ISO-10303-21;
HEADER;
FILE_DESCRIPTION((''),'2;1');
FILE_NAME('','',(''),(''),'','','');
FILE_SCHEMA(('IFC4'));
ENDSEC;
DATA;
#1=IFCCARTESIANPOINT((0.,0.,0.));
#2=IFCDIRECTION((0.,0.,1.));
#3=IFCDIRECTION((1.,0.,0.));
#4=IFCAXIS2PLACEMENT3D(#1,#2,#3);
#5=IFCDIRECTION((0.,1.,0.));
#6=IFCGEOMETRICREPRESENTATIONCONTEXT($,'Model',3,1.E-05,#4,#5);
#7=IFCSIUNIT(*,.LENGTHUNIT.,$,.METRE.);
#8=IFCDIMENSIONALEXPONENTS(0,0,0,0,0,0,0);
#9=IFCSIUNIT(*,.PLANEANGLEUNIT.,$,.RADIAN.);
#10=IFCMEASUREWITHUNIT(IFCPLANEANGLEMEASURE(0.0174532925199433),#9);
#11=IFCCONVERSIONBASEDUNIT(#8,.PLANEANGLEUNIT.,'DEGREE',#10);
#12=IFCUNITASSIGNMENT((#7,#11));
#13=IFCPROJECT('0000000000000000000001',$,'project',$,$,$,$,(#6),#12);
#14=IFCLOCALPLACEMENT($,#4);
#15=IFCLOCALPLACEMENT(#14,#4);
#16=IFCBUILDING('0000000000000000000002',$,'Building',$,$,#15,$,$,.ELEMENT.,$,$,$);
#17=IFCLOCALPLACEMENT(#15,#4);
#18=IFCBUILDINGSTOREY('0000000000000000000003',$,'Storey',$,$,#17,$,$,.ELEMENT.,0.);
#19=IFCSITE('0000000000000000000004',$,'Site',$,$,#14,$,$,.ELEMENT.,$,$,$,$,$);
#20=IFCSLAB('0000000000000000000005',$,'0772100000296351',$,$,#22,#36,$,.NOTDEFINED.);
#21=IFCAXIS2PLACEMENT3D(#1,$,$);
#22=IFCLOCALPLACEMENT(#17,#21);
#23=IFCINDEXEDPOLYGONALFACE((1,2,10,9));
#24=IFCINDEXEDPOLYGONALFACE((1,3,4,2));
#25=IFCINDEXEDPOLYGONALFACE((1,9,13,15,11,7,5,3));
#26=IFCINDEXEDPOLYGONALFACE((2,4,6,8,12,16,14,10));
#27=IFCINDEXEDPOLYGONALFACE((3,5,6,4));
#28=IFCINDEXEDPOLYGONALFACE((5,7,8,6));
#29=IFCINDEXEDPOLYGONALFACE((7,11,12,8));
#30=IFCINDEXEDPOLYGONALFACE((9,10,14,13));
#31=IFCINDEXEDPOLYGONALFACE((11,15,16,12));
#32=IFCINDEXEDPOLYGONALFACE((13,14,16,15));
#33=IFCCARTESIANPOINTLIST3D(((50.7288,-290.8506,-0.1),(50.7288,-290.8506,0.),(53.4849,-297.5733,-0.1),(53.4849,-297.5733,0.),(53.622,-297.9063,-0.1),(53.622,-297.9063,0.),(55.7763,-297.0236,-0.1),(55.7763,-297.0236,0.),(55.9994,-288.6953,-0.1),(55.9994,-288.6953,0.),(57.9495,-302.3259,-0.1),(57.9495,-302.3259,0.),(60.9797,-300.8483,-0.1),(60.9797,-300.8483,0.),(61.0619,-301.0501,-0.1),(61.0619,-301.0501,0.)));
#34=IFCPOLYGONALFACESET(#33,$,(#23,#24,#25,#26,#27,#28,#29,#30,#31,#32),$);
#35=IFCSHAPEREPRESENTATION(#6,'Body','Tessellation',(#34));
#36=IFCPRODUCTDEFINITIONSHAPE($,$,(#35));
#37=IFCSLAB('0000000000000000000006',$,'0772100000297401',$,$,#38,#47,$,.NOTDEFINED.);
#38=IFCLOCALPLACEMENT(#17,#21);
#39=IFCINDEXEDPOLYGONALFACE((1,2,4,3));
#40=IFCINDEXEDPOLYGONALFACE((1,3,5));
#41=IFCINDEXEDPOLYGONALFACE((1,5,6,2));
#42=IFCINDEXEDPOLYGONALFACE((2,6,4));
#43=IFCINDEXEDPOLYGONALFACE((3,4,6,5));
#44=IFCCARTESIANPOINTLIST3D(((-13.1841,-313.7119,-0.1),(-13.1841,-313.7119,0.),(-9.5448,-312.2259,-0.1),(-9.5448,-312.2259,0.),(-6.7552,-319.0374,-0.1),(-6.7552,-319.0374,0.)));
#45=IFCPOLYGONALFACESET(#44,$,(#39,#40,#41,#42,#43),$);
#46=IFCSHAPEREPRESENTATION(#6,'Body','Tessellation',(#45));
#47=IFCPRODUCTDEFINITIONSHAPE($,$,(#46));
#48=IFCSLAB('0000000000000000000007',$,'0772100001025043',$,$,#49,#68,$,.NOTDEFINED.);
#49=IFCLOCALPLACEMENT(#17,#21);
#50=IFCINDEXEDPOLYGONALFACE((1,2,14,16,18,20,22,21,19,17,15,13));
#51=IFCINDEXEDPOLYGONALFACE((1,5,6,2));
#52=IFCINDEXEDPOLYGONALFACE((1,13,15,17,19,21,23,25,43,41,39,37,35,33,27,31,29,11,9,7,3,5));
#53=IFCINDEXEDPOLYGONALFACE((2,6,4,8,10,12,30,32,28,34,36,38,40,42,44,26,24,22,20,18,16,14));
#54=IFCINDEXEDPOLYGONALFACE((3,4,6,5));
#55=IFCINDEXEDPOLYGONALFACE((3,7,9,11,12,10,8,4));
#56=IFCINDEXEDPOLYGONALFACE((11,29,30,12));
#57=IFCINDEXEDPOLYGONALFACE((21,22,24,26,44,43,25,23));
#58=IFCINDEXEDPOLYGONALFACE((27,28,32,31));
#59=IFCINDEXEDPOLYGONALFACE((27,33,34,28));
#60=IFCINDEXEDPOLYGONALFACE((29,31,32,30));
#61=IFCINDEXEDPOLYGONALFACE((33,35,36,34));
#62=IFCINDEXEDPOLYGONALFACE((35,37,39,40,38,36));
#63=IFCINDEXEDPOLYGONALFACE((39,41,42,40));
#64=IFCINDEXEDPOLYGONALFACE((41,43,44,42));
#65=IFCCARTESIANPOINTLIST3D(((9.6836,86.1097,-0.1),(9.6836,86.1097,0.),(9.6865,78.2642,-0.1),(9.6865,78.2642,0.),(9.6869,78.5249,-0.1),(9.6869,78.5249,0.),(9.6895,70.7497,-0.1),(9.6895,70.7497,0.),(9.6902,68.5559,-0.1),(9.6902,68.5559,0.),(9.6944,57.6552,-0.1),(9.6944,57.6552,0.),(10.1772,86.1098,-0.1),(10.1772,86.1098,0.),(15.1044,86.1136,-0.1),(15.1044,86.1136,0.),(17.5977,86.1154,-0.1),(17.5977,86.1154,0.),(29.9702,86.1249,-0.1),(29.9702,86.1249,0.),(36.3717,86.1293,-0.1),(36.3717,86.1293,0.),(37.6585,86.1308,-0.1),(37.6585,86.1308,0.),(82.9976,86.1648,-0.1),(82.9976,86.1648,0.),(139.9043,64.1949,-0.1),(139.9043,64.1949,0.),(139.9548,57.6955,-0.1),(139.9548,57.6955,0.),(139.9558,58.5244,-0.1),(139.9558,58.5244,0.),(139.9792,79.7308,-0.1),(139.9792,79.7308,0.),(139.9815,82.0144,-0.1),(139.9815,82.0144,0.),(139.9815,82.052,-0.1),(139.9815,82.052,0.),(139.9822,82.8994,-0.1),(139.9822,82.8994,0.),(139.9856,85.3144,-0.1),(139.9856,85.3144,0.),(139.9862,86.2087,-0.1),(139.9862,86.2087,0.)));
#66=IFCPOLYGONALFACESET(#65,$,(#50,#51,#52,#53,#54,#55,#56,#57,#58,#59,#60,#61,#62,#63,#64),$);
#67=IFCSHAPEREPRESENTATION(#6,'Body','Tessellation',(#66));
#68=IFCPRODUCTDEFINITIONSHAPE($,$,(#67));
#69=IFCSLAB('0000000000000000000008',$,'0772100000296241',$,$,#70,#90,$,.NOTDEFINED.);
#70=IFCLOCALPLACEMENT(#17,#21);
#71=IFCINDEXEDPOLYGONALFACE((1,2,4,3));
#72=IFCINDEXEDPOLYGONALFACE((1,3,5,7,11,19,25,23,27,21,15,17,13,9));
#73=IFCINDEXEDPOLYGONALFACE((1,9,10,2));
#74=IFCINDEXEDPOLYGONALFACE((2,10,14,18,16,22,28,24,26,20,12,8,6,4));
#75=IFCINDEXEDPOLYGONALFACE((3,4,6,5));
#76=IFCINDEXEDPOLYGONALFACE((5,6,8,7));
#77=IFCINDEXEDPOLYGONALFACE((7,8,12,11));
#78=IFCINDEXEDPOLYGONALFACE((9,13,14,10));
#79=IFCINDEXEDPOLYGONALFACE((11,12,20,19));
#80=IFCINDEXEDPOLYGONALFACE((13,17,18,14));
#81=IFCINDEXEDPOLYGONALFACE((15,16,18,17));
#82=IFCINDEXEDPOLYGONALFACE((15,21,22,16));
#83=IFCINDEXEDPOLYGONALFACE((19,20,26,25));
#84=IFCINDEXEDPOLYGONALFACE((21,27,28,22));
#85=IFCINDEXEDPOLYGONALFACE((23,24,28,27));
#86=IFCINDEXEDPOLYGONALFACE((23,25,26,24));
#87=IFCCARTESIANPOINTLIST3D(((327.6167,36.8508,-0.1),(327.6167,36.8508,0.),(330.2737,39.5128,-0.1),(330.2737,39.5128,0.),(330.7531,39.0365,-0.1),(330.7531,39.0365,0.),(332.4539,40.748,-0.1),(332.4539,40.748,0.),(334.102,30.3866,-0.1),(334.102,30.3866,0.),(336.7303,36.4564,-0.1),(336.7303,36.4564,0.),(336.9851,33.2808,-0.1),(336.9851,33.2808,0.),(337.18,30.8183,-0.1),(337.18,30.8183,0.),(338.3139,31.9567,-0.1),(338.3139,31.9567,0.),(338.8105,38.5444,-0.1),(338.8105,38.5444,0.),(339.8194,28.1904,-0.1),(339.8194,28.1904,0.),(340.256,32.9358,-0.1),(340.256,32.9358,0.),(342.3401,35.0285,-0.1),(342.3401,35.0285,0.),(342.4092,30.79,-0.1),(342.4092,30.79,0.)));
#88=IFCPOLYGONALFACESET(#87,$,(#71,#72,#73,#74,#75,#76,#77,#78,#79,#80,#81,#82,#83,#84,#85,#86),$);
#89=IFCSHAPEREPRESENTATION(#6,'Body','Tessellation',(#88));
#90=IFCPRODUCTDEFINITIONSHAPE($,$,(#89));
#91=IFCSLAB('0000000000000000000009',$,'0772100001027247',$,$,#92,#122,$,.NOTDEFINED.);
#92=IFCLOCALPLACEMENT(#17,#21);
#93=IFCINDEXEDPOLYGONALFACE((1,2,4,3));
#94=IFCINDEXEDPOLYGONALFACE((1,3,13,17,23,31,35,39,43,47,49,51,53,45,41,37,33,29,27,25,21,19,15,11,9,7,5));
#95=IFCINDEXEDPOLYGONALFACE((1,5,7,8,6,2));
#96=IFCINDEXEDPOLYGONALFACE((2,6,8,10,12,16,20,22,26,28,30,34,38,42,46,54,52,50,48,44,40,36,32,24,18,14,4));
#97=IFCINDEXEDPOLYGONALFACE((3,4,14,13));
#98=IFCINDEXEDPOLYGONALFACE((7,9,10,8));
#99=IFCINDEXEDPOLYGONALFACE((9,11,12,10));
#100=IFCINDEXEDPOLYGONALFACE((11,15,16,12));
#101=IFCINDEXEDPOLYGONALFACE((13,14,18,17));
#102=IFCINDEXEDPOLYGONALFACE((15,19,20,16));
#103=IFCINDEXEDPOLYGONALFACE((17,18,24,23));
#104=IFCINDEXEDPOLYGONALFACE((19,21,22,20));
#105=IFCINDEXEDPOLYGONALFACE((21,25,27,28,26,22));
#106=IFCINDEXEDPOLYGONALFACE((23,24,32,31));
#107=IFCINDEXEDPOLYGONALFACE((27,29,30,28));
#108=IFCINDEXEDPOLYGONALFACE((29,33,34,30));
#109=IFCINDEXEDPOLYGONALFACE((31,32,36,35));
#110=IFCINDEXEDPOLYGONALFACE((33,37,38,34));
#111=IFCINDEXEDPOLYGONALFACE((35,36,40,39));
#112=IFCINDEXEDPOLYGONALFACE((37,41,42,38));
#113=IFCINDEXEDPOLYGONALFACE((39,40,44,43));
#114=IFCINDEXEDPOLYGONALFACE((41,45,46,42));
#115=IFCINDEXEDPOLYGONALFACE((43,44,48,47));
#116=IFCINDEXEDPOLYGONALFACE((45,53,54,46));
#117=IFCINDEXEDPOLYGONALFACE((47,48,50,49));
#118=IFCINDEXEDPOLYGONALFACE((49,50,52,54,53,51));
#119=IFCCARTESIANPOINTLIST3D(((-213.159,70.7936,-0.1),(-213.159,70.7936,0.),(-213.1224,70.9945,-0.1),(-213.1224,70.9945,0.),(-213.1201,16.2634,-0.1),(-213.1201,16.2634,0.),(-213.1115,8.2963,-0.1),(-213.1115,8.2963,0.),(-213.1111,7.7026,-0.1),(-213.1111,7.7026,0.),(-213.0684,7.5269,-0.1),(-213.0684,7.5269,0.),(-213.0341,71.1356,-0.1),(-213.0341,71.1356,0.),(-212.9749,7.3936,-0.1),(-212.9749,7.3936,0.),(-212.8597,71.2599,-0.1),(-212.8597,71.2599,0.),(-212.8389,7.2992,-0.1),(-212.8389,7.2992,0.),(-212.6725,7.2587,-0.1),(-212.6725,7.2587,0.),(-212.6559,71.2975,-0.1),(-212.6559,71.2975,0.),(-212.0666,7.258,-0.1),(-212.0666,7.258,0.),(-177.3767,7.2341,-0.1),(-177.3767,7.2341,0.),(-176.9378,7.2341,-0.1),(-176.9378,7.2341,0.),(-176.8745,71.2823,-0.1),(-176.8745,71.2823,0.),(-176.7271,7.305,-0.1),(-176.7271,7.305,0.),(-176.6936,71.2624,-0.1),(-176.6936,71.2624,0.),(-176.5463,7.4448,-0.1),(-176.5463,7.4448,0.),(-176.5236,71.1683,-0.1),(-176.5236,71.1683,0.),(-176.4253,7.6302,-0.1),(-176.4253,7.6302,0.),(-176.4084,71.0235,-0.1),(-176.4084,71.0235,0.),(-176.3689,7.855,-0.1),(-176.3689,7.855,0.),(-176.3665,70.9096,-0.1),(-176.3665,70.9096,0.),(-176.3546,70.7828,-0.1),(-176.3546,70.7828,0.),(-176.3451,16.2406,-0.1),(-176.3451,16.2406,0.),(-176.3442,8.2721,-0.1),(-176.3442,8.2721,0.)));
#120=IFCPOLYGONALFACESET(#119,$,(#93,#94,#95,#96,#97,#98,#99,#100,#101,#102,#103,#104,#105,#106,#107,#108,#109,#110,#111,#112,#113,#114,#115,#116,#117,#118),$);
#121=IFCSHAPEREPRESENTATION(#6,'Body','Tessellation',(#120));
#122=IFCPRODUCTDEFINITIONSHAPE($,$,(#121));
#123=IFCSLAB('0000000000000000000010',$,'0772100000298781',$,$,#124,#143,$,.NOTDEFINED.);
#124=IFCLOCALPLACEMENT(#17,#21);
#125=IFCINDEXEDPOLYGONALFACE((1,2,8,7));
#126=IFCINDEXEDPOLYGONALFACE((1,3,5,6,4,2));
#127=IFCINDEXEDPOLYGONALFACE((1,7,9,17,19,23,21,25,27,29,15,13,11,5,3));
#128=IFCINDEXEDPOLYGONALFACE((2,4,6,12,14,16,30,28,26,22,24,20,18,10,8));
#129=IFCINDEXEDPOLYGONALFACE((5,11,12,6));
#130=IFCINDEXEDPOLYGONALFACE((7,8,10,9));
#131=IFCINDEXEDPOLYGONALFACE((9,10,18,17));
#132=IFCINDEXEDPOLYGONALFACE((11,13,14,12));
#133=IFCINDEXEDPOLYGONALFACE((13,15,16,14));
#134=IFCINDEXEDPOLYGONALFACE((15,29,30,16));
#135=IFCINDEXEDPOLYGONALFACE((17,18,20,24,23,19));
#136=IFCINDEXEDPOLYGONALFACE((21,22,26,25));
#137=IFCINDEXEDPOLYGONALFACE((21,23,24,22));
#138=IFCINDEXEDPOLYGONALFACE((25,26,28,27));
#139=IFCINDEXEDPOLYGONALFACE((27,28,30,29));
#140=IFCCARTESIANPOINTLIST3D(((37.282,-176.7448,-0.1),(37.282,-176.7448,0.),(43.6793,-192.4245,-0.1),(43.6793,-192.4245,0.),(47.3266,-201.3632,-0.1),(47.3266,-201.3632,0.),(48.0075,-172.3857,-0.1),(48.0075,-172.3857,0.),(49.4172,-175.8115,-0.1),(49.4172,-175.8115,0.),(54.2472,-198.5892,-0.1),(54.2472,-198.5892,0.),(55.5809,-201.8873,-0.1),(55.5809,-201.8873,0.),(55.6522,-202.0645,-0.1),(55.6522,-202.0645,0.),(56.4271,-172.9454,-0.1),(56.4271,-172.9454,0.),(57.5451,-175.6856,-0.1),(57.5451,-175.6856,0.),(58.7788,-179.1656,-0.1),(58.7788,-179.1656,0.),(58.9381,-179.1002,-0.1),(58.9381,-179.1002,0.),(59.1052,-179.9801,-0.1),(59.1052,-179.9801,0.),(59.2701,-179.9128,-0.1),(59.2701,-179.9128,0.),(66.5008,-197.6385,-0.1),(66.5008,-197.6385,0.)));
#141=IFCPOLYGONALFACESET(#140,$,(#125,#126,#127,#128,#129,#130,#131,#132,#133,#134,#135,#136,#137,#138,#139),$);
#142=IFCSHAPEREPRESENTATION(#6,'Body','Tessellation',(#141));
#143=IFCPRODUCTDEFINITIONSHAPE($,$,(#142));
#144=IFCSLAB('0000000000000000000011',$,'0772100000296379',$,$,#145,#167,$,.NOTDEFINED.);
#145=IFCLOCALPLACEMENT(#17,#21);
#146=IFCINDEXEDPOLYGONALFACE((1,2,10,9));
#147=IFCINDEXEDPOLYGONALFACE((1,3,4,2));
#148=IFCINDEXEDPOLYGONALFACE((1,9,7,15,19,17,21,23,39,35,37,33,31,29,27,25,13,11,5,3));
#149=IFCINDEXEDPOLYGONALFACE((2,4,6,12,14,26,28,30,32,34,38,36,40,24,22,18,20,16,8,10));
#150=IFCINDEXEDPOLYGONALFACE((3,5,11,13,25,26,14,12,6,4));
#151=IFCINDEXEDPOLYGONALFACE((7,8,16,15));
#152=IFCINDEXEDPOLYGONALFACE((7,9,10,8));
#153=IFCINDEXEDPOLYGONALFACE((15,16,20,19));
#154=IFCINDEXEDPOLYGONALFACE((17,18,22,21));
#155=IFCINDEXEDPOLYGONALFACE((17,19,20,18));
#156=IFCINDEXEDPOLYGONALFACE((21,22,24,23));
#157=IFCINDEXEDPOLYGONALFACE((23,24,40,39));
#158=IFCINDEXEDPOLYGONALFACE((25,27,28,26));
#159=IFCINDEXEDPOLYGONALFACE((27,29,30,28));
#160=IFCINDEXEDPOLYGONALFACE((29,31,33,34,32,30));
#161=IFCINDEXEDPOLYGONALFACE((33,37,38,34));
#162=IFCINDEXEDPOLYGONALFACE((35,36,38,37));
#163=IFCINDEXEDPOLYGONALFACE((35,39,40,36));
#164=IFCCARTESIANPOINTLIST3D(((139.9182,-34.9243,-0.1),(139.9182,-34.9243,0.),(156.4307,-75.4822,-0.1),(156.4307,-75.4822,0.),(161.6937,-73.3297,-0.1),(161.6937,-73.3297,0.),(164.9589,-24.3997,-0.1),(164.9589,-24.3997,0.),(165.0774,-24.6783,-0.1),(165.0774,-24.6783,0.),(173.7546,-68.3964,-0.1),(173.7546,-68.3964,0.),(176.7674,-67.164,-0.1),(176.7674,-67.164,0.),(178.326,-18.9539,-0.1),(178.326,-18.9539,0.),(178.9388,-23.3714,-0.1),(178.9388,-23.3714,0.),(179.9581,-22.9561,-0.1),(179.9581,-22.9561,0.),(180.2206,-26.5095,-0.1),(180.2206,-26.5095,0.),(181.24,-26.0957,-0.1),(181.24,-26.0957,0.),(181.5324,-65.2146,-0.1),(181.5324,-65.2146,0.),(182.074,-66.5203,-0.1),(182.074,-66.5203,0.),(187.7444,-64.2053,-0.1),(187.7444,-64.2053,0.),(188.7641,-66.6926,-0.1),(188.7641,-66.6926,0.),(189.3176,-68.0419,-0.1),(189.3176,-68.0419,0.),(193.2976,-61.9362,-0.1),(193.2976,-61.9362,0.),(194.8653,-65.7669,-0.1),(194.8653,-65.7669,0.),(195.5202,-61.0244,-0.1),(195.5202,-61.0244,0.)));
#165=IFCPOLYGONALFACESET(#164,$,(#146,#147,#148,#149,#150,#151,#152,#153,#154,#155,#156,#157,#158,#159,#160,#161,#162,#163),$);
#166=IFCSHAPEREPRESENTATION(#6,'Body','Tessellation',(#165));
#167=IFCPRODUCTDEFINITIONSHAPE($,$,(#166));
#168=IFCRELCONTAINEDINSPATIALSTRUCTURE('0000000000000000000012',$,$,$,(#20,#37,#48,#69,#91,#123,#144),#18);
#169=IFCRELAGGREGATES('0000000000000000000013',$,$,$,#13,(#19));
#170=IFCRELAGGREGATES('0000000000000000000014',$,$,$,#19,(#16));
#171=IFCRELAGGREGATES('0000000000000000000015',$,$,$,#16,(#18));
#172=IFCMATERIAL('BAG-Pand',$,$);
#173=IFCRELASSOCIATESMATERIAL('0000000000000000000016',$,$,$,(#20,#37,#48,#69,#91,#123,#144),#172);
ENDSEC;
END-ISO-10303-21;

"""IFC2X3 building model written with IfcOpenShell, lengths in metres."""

from ifc_helpers import new_model, entity, si_unit, converted_unit, direction, frame, origin_with_axes, place, context, project, spatial, polyline, outline, extrude, material, element, save


model = new_model("IFC2X3")

# Units and contexts
model_context = context("Model", 3, precision=1e-05, world=origin_with_axes(), true_north=direction((0.0, 1.0, 0.0)))
ifc_project = project(units=[si_unit("LENGTHUNIT", "METRE"), converted_unit("PLANEANGLEUNIT", "DEGREE", entity("IfcPlaneAngleMeasure", 0.0174532925199433), si_unit("PLANEANGLEUNIT", "RADIAN"), dimensions=[0, 0, 0, 0, 0, 0, 0])], contexts=[model_context])

# Site, building, storey
site_placement = place(None, origin_with_axes())
site = spatial("IfcSite", under=ifc_project, at=site_placement, Name="Site", CompositionType="ELEMENT")
building_placement = place(site_placement, origin_with_axes())
building = spatial("IfcBuilding", under=site, at=building_placement, Name="Building", CompositionType="ELEMENT")
storey_placement = place(building_placement, origin_with_axes())
storey = spatial("IfcBuildingStorey", under=building, at=storey_placement, Name="Storey", CompositionType="ELEMENT", Elevation=0.0)

# Slabs
ifc_material = material(Name="BAG-Pand")
slab_1_placement = place(storey_placement, frame((0.0, 0.0, -0.1), z_axis=(0.0, 0.0, 1.0), x_axis=(1.0, 0.0, 0.0)))
element("IfcSlab", 1, at=slab_1_placement, inside=storey, material=ifc_material, Name="0772100000296351", PredefinedType="NOTDEFINED", context=model_context, shape_type="SweptSolid", body=[
    extrude(outline(polyline([(53.622, -297.9063), (53.4849, -297.5733), (50.7288, -290.8506), (55.9994, -288.6953), (60.9797, -300.8483), (61.0619, -301.0501), (57.9495, -302.3259), (55.7763, -297.0236), (53.622, -297.9063)])), origin_with_axes(), (0.0, 0.0, 1.0), 0.1),
])
slab_2_placement = place(storey_placement, frame((0.0, 0.0, -0.1), z_axis=(0.0, 0.0, 1.0), x_axis=(1.0, 0.0, 0.0)))
element("IfcSlab", 2, at=slab_2_placement, inside=storey, material=ifc_material, Name="0772100000297401", PredefinedType="NOTDEFINED", context=model_context, shape_type="SweptSolid", body=[
    extrude(outline(polyline([(-9.5448, -312.2259), (-6.7552, -319.0374), (-13.1841, -313.7119), (-9.5448, -312.2259)])), origin_with_axes(), (0.0, 0.0, 1.0), 0.1),
])
slab_3_placement = place(storey_placement, frame((0.0, 0.0, -0.1), z_axis=(0.0, 0.0, 1.0), x_axis=(1.0, 0.0, 0.0)))
element("IfcSlab", 3, at=slab_3_placement, inside=storey, material=ifc_material, Name="0772100001025043", PredefinedType="NOTDEFINED", context=model_context, shape_type="SweptSolid", body=[
    extrude(outline(polyline([(9.6902, 68.5559), (9.6895, 70.7497), (9.6865, 78.2642), (9.6869, 78.5249), (9.6836, 86.1097), (10.1772, 86.1098), (15.1044, 86.1136), (17.5977, 86.1154), (29.9702, 86.1249), (36.3717, 86.1293), (37.6585, 86.1308), (82.9976, 86.1648), (139.9862, 86.2087), (139.9856, 85.3144), (139.9822, 82.8994), (139.9815, 82.052), (139.9815, 82.0144), (139.9792, 79.7308), (139.9043, 64.1949), (139.9558, 58.5244), (139.9548, 57.6955), (9.6944, 57.6552), (9.6902, 68.5559)])), origin_with_axes(), (0.0, 0.0, 1.0), 0.1),
])
slab_4_placement = place(storey_placement, frame((0.0, 0.0, -0.1), z_axis=(0.0, 0.0, 1.0), x_axis=(1.0, 0.0, 0.0)))
element("IfcSlab", 4, at=slab_4_placement, inside=storey, material=ifc_material, Name="0772100000296241", PredefinedType="NOTDEFINED", context=model_context, shape_type="SweptSolid", body=[
    extrude(outline(polyline([(327.6167, 36.8508), (330.2737, 39.5128), (330.7531, 39.0365), (332.4539, 40.748), (336.7303, 36.4564), (338.8105, 38.5444), (342.3401, 35.0285), (340.256, 32.9358), (342.4092, 30.79), (339.8194, 28.1904), (337.18, 30.8183), (338.3139, 31.9567), (336.9851, 33.2808), (334.102, 30.3866), (327.6167, 36.8508)])), origin_with_axes(), (0.0, 0.0, 1.0), 0.1),
])
slab_5_placement = place(storey_placement, frame((0.0, 0.0, -0.1), z_axis=(0.0, 0.0, 1.0), x_axis=(1.0, 0.0, 0.0)))
element("IfcSlab", 5, at=slab_5_placement, inside=storey, material=ifc_material, Name="0772100001027247", PredefinedType="NOTDEFINED", context=model_context, shape_type="SweptSolid", body=[
    extrude(outline(polyline([(-213.0684, 7.5269), (-213.1111, 7.7026), (-213.1115, 8.2963), (-213.1201, 16.2634), (-213.159, 70.7936), (-213.1224, 70.9945), (-213.0341, 71.1356), (-212.8597, 71.2599), (-212.6559, 71.2975), (-176.8745, 71.2823), (-176.6936, 71.2624), (-176.5236, 71.1683), (-176.4084, 71.0235), (-176.3665, 70.9096), (-176.3546, 70.7828), (-176.3451, 16.2406), (-176.3442, 8.2721), (-176.3689, 7.855), (-176.4253, 7.6302), (-176.5463, 7.4448), (-176.7271, 7.305), (-176.9378, 7.2341), (-177.3767, 7.2341), (-212.0666, 7.258), (-212.6725, 7.2587), (-212.8389, 7.2992), (-212.9749, 7.3936), (-213.0684, 7.5269)])), origin_with_axes(), (0.0, 0.0, 1.0), 0.1),
])
slab_6_placement = place(storey_placement, frame((0.0, 0.0, -0.1), z_axis=(0.0, 0.0, 1.0), x_axis=(1.0, 0.0, 0.0)))
element("IfcSlab", 6, at=slab_6_placement, inside=storey, material=ifc_material, Name="0772100000298781", PredefinedType="NOTDEFINED", context=model_context, shape_type="SweptSolid", body=[
    extrude(outline(polyline([(54.2472, -198.5892), (47.3266, -201.3632), (43.6793, -192.4245), (37.282, -176.7448), (48.0075, -172.3857), (49.4172, -175.8115), (56.4271, -172.9454), (57.5451, -175.6856), (58.9381, -179.1002), (58.7788, -179.1656), (59.1052, -179.9801), (59.2701, -179.9128), (66.5008, -197.6385), (55.6522, -202.0645), (55.5809, -201.8873), (54.2472, -198.5892)])), origin_with_axes(), (0.0, 0.0, 1.0), 0.1),
])
slab_7_placement = place(storey_placement, frame((0.0, 0.0, -0.1), z_axis=(0.0, 0.0, 1.0), x_axis=(1.0, 0.0, 0.0)))
element("IfcSlab", 7, at=slab_7_placement, inside=storey, material=ifc_material, Name="0772100000296379", PredefinedType="NOTDEFINED", context=model_context, shape_type="SweptSolid", body=[
    extrude(outline(polyline([(156.4307, -75.4822), (139.9182, -34.9243), (165.0774, -24.6783), (164.9589, -24.3997), (178.326, -18.9539), (179.9581, -22.9561), (178.9388, -23.3714), (180.2206, -26.5095), (181.24, -26.0957), (195.5202, -61.0244), (193.2976, -61.9362), (194.8653, -65.7669), (189.3176, -68.0419), (188.7641, -66.6926), (187.7444, -64.2053), (182.074, -66.5203), (181.5324, -65.2146), (176.7674, -67.164), (173.7546, -68.3964), (161.6937, -73.3297), (156.4307, -75.4822)])), origin_with_axes(), (0.0, 0.0, 1.0), 0.1),
])

save(model, "model.ifc")
